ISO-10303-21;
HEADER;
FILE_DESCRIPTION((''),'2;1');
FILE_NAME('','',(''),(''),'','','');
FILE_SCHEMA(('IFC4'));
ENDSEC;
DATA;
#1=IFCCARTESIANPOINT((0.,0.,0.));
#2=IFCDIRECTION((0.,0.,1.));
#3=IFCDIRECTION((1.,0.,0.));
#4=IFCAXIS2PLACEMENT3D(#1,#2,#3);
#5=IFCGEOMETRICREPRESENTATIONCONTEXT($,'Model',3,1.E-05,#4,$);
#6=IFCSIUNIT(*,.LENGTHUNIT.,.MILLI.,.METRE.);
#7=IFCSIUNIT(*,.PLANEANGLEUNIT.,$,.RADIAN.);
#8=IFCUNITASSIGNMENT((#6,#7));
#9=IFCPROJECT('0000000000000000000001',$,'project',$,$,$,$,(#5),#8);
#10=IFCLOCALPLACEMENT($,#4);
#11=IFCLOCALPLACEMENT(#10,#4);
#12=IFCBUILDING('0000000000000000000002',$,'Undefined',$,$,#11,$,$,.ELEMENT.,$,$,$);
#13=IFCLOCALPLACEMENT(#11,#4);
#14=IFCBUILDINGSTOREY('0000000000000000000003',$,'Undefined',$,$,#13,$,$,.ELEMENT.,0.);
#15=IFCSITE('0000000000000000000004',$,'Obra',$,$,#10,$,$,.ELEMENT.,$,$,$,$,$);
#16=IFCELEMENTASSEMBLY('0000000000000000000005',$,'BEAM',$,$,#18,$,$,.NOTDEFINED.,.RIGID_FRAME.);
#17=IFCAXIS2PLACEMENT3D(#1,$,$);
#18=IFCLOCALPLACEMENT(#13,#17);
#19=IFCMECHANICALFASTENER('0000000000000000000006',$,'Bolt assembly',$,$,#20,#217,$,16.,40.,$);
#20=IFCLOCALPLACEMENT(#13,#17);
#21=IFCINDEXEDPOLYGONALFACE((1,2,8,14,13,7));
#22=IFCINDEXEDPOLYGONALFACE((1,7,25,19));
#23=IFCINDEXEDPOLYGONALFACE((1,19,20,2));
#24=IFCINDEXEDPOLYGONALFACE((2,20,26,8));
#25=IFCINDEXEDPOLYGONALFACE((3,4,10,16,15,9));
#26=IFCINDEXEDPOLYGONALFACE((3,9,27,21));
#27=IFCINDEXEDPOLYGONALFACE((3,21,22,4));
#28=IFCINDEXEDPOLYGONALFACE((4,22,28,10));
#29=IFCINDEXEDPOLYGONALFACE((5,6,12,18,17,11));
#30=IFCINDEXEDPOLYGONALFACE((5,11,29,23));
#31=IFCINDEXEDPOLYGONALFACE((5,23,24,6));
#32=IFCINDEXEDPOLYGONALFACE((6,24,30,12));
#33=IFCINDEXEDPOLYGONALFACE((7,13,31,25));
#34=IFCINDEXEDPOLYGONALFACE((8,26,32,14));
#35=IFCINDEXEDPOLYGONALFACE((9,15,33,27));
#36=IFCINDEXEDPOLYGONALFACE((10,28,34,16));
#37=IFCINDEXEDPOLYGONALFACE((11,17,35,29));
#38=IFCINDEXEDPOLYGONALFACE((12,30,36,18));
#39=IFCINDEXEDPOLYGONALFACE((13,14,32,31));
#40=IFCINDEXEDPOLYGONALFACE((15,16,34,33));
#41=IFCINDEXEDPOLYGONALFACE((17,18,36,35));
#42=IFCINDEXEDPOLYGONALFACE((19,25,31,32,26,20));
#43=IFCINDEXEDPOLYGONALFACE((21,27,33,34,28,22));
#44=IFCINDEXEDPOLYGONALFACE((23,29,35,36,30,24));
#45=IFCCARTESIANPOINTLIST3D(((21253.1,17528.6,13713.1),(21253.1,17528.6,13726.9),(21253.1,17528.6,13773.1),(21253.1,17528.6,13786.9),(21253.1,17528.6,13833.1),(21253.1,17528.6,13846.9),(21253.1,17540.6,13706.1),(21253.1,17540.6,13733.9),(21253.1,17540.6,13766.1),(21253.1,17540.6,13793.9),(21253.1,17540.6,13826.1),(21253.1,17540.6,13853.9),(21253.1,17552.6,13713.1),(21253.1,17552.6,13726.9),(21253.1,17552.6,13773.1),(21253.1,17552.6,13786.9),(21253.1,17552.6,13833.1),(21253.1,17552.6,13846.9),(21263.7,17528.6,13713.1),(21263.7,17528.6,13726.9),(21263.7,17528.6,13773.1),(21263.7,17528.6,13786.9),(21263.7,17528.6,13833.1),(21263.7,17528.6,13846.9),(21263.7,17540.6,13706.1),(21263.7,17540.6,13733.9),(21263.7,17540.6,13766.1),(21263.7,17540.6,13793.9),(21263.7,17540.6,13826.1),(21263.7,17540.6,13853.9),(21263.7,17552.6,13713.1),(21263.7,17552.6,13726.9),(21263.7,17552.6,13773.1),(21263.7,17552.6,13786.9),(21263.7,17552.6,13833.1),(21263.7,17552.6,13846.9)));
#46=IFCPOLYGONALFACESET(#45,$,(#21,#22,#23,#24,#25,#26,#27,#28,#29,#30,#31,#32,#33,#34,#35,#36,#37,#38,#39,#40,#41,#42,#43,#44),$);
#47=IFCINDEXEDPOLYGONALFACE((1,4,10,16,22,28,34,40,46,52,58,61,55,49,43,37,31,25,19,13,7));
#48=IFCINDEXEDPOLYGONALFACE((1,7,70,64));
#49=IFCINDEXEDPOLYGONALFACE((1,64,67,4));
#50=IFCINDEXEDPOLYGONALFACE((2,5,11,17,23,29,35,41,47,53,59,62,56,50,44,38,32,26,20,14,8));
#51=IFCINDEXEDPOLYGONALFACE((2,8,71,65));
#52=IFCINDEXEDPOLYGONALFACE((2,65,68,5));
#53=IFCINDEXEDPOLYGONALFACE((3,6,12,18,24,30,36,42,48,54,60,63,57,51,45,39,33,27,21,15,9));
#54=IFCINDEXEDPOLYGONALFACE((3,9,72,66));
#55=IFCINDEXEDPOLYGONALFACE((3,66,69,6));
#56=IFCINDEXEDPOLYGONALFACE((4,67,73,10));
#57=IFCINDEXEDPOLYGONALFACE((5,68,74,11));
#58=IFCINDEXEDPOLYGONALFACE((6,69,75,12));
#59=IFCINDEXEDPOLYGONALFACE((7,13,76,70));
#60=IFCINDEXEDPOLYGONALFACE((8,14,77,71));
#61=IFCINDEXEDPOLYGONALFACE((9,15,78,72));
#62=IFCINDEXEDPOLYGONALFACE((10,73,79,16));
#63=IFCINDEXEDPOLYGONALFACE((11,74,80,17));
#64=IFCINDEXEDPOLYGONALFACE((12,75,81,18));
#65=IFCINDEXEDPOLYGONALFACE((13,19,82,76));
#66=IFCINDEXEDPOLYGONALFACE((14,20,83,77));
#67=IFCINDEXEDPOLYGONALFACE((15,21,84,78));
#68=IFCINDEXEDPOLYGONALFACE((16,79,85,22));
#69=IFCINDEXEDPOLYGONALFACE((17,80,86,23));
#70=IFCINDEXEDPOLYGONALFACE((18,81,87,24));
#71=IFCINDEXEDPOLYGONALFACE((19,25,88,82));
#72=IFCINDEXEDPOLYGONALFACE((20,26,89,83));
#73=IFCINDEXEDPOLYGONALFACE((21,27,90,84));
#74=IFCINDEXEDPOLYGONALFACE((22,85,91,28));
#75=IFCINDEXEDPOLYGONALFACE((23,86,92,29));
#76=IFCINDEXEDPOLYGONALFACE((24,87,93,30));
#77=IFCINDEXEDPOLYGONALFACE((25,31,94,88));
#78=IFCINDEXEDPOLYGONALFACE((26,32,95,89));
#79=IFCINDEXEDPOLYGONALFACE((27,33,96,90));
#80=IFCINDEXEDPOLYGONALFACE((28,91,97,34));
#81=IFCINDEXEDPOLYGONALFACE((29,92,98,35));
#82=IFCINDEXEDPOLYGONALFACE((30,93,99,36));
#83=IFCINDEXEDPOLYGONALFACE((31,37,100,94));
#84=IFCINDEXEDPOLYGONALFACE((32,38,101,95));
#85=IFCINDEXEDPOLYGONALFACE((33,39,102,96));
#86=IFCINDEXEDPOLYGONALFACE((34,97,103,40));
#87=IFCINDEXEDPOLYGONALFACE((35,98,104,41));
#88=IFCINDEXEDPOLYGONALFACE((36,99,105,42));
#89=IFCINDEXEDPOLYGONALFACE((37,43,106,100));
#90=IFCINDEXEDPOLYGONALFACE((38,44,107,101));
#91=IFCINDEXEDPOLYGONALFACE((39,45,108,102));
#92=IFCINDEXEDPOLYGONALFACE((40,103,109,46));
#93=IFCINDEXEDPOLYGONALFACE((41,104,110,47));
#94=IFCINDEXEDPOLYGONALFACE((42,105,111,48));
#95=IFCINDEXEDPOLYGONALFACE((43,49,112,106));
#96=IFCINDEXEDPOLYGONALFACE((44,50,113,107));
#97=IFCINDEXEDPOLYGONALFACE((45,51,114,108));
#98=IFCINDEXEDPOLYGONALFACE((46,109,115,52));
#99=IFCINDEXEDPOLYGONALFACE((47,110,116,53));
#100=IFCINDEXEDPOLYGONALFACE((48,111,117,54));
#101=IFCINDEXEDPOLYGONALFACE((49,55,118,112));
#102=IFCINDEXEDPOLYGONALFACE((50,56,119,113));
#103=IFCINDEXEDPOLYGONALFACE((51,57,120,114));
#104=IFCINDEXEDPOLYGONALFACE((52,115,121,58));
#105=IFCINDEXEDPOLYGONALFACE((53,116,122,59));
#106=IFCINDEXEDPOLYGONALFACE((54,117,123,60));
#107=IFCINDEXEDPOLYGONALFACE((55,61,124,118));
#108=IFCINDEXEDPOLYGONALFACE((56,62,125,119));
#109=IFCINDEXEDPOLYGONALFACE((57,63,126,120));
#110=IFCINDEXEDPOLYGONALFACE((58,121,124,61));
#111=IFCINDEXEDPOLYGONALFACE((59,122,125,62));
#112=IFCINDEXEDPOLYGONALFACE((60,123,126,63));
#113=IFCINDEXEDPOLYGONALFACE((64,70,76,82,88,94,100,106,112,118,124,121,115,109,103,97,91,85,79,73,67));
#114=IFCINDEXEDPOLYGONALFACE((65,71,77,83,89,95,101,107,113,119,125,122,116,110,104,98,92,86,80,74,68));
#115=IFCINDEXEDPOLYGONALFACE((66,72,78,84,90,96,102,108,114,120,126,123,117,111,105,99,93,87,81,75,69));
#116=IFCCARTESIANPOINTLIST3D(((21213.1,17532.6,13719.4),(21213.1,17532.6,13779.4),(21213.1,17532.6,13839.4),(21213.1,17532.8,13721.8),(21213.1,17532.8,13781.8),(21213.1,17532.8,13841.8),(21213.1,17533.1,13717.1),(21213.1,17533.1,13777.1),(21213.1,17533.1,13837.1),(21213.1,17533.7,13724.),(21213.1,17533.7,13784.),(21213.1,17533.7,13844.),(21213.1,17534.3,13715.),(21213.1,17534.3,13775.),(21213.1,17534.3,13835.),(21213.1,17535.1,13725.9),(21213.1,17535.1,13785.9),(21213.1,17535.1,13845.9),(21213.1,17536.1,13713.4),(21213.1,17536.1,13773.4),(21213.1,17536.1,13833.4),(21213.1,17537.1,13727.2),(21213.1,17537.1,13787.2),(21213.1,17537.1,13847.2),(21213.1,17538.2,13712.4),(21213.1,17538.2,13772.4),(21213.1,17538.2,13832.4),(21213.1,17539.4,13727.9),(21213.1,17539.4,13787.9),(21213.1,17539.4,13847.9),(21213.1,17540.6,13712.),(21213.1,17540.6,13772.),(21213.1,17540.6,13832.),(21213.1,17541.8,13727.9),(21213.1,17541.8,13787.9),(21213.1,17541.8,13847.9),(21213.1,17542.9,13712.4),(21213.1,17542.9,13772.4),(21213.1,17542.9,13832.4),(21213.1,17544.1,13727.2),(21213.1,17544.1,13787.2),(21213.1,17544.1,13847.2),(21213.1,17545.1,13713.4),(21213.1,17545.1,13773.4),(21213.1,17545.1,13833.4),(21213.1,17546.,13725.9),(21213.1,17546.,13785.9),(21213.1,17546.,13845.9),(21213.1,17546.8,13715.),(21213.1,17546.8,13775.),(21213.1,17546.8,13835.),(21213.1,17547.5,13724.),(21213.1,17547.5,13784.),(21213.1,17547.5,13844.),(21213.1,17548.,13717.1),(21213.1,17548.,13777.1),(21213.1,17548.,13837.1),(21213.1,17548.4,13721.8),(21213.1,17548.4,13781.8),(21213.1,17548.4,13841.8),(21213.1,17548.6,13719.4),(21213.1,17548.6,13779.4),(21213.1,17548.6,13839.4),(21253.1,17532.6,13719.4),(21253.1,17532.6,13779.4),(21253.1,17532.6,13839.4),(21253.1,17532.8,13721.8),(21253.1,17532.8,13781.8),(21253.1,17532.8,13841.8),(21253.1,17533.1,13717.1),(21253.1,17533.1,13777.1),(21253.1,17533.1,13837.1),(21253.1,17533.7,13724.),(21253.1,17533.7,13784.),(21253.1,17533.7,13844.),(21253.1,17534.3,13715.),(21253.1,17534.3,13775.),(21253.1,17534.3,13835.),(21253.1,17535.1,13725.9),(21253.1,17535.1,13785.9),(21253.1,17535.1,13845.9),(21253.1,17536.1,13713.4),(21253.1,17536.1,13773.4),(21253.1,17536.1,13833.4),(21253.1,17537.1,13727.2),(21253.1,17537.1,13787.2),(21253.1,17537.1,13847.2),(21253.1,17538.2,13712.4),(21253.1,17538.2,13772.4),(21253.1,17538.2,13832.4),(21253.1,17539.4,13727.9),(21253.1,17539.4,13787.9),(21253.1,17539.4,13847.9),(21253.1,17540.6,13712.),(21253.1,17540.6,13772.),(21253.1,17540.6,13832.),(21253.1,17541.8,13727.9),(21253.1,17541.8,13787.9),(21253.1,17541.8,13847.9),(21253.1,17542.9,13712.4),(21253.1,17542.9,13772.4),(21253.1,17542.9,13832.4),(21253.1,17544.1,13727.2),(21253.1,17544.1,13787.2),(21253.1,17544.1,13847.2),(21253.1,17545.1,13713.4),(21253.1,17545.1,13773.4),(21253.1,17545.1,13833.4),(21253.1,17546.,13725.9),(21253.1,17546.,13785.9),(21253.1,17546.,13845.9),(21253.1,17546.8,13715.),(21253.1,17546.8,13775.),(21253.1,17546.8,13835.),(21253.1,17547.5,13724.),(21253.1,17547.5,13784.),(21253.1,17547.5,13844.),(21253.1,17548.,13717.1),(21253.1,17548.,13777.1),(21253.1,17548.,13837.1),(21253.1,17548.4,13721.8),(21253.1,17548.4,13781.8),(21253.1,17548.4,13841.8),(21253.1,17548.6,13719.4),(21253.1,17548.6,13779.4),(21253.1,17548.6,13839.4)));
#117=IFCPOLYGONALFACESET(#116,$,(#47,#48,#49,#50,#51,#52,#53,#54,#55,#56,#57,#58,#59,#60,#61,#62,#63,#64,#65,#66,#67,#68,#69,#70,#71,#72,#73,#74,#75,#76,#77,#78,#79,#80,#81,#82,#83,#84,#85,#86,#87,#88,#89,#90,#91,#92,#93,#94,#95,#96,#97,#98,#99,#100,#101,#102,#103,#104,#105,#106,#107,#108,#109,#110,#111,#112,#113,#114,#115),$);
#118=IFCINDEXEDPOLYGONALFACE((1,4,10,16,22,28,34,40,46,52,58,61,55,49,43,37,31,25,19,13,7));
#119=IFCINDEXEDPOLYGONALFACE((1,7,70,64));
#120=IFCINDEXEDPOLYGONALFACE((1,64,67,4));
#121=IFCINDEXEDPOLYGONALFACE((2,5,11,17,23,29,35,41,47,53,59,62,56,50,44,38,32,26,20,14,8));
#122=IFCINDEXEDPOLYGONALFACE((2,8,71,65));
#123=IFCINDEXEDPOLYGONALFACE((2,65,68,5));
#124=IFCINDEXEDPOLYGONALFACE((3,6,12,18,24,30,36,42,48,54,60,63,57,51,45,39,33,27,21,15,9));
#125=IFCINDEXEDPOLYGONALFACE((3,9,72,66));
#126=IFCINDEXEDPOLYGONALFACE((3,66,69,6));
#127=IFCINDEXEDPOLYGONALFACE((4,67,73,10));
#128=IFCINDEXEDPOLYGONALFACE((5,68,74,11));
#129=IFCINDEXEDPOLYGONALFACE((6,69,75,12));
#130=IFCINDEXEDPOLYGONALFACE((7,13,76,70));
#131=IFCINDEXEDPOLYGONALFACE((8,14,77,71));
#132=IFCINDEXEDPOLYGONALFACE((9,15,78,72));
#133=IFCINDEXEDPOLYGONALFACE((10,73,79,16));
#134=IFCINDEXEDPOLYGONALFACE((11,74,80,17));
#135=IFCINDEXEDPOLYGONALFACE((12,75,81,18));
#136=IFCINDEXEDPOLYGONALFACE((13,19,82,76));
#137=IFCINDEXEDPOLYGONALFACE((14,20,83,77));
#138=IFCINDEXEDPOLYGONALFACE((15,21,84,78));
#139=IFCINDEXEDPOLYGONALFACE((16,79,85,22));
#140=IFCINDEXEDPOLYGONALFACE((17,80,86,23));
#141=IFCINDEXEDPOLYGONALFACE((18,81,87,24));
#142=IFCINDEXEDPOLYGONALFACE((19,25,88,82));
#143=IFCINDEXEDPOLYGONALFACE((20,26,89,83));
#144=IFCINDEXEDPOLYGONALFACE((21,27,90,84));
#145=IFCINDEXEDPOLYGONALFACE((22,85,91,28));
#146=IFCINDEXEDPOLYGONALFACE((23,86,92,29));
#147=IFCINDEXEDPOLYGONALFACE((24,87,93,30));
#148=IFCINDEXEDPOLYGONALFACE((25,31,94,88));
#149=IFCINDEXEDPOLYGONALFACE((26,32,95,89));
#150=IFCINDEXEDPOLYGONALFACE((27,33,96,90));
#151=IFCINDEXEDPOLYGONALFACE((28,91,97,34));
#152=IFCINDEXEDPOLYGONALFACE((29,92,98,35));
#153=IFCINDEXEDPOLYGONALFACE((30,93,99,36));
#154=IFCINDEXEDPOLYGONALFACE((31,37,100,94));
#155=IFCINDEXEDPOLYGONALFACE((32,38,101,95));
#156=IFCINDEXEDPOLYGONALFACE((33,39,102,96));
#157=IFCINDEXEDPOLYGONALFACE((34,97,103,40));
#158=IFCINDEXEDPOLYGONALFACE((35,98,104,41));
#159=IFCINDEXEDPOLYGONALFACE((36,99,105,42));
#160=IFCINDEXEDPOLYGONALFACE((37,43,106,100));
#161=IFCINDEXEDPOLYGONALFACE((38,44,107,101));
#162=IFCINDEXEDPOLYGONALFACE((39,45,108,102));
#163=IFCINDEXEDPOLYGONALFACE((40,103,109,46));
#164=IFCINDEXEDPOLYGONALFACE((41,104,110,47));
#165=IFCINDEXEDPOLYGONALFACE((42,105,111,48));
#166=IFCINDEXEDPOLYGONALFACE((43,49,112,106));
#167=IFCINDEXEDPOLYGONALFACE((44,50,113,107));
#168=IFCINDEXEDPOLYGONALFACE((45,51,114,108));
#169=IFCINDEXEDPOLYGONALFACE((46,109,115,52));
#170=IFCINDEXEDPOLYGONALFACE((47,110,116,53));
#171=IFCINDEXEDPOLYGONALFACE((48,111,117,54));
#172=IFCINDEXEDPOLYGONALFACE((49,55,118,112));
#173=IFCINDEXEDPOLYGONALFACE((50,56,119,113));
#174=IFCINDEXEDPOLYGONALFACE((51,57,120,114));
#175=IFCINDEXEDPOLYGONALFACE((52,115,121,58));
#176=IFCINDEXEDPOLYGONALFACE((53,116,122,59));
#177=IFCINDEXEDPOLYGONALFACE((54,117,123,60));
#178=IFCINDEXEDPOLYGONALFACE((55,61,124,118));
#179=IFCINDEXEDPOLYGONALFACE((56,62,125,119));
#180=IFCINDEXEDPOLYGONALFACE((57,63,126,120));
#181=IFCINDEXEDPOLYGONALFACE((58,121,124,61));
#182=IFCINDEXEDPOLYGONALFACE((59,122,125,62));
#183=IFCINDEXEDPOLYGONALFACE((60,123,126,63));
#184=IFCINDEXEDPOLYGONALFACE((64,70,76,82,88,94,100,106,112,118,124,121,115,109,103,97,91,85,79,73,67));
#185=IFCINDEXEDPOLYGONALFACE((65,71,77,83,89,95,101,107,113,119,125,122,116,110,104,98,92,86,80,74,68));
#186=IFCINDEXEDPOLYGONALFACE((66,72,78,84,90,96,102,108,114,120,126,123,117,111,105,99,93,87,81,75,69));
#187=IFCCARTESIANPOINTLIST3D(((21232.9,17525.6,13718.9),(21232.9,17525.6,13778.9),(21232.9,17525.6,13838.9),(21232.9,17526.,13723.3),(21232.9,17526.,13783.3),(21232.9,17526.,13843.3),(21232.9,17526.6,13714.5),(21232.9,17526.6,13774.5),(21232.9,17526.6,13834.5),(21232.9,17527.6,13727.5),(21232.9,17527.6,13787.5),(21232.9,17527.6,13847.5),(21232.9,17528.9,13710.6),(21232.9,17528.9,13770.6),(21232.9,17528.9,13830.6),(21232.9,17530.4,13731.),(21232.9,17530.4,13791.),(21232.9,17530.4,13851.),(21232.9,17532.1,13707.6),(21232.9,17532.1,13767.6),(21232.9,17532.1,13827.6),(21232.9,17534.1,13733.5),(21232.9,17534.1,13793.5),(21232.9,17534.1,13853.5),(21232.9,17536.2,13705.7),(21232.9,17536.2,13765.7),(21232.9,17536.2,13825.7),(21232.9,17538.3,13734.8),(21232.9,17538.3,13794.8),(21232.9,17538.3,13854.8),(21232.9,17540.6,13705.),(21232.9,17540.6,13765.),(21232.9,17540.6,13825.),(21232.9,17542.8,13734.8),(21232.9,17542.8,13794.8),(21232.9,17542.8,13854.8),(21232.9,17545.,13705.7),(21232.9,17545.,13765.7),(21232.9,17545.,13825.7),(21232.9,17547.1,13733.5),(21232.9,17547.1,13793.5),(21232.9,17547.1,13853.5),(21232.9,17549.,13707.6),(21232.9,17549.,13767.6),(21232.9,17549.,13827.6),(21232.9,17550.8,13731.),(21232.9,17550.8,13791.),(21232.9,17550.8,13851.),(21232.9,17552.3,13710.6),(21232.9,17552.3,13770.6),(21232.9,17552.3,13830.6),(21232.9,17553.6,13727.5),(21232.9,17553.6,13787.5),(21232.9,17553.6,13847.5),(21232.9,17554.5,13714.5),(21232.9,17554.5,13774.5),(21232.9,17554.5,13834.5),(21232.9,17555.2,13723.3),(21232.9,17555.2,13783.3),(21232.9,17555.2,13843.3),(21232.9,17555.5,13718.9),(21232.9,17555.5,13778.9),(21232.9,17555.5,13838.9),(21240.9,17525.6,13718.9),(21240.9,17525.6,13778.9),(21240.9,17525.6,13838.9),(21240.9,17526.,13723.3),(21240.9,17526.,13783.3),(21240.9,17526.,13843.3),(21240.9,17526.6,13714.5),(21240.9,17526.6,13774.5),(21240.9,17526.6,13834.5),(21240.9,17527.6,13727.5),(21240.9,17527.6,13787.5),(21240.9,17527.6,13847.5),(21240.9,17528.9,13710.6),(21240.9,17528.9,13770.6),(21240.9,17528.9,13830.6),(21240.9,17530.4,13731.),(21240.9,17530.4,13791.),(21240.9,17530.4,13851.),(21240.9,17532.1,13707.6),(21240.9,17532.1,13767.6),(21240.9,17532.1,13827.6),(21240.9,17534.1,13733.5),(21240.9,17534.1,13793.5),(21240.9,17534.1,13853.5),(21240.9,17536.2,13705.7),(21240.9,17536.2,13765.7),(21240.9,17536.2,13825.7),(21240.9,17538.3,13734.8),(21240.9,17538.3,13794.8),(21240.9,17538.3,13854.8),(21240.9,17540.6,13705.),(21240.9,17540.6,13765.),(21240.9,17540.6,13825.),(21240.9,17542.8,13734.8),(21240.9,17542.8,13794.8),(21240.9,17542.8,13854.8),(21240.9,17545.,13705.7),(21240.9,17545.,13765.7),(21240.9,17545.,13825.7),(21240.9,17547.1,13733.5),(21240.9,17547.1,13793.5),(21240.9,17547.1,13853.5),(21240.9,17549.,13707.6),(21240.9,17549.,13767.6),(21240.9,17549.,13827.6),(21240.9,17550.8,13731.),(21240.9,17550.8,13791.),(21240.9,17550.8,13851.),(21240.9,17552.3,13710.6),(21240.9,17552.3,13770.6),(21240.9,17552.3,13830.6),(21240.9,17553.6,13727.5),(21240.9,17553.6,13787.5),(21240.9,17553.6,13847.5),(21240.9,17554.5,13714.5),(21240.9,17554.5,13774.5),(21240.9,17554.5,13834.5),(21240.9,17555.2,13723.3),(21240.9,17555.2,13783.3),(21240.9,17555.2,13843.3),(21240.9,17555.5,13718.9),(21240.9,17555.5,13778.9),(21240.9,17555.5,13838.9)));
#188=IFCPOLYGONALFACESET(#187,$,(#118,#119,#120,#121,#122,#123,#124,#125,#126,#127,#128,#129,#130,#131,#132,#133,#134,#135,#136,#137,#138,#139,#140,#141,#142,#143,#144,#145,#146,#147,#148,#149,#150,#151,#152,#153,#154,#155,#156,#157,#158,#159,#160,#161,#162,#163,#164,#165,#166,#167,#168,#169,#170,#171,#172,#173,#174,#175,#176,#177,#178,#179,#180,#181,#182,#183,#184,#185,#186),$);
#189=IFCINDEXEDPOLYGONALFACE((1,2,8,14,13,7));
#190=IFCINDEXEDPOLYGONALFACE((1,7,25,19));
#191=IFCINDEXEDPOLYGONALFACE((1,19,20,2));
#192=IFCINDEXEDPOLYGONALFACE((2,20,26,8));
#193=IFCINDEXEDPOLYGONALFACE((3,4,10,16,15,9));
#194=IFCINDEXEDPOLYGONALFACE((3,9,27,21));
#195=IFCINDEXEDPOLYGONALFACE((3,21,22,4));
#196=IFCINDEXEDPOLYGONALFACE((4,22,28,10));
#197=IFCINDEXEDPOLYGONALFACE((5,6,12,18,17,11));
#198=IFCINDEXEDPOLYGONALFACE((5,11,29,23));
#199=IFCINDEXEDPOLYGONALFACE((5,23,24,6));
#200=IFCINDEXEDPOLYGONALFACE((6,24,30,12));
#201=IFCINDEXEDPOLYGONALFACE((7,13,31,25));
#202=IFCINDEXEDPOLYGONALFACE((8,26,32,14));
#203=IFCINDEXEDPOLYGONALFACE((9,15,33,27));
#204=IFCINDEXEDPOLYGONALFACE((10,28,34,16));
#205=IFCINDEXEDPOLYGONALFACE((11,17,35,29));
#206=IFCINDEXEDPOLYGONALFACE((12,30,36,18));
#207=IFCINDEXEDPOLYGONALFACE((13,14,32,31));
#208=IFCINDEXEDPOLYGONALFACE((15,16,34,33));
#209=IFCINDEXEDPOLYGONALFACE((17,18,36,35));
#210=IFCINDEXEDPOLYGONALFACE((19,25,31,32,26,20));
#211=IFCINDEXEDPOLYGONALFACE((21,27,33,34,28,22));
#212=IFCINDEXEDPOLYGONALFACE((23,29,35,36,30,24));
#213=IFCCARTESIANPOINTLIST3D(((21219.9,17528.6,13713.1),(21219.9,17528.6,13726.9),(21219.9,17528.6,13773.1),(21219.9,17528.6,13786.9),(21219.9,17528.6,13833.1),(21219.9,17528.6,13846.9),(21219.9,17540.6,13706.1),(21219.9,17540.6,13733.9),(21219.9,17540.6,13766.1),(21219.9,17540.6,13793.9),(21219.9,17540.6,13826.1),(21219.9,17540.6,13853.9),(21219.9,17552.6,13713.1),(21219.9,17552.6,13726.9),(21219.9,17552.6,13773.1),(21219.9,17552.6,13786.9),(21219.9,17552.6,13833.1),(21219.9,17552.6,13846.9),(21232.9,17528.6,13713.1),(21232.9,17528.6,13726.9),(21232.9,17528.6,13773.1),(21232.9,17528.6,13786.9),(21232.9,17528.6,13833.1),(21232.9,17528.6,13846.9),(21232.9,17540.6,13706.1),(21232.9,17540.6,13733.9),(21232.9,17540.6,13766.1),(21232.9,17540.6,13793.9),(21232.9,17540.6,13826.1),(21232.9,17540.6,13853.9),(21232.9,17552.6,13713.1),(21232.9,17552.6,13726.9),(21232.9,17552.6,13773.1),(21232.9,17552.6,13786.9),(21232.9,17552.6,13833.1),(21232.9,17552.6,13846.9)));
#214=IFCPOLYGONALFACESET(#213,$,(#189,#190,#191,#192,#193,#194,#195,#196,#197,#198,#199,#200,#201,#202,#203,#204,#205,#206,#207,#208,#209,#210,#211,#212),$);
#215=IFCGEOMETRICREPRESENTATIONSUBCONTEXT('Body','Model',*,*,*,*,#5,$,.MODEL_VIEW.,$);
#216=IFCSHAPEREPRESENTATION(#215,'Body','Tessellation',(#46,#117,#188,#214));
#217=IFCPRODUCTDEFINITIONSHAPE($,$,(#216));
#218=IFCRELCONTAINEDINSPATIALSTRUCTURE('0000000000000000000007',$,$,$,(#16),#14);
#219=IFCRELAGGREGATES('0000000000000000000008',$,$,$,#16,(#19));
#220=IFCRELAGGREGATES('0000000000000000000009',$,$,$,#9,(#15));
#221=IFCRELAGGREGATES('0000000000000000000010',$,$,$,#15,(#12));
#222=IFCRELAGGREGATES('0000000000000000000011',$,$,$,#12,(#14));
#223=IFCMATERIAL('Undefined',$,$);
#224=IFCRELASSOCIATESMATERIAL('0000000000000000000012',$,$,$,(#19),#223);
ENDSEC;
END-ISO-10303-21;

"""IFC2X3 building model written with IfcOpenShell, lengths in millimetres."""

from ifc_helpers import new_model, si_unit, frame, origin_with_axes, origin_2d_with_axis, place, context, subcontext, project, spatial, polyline, circle, outline, extrude, source, transform, mapped, material, element, aggregate, save


model = new_model("IFC2X3")

# Units and contexts
model_context = context("Model", 3, precision=1e-05, world=origin_with_axes())
body_context = subcontext(model_context, "Body", "Model", "MODEL_VIEW")
ifc_project = project(units=[si_unit("LENGTHUNIT", "METRE", prefix="MILLI"), si_unit("PLANEANGLEUNIT", "RADIAN")], contexts=[model_context])

# Site, building, storey
site_placement = place(None, origin_with_axes())
site = spatial("IfcSite", under=ifc_project, at=site_placement, Name="Obra", CompositionType="ELEMENT")
building_placement = place(site_placement, origin_with_axes())
building = spatial("IfcBuilding", under=site, at=building_placement, Name="Undefined", CompositionType="ELEMENT")
storey_placement = place(building_placement, origin_with_axes())
storey = spatial("IfcBuildingStorey", under=building, at=storey_placement, Name="Undefined", CompositionType="ELEMENT", Elevation=0.0)

# Element assembly
assembly_1_placement = place(storey_placement, origin_with_axes())
assembly_1 = element("IfcElementAssembly", 1, at=assembly_1_placement, inside=storey, Name="BEAM", AssemblyPlace="NOTDEFINED", PredefinedType="RIGID_FRAME")

# Shared definitions
ifc_material_1 = material(Name="Undefined")
shared_shape_1 = source(origin_with_axes(), body_context, "Body", "SweptSolid", [
    extrude(outline(polyline([(13.9, 0.0), (6.9, 12.0), (-6.9, 12.0), (-13.9, 0.0), (-6.9, -12.0), (6.9, -12.0), (13.9, 0.0)])), frame((0.0, -13.6, 0.0), z_axis=(0.0, 1.0, 0.0), x_axis=(1.0, 0.0, 0.0)), (0.0, 0.0, 1.0), 10.6),
    extrude(circle(Radius=8.0, at=origin_2d_with_axis()), frame((0.0, -3.1, 0.0), z_axis=(0.0, 1.0, 0.0), x_axis=(1.0, 0.0, 0.0)), (0.0, 0.0, 1.0), 40.0),
    extrude(circle(Radius=15.0, at=origin_2d_with_axis()), frame((0.0, 9.1, 0.0), z_axis=(0.0, 1.0, 0.0), x_axis=(1.0, 0.0, 0.0)), (0.0, 0.0, 1.0), 8.0),
    extrude(outline(polyline([(13.9, 0.0), (6.9, 12.0), (-6.9, 12.0), (-13.9, 0.0), (-6.9, -12.0), (6.9, -12.0), (13.9, 0.0)])), frame((0.0, 17.1, 0.0), z_axis=(0.0, 1.0, 0.0), x_axis=(1.0, 0.0, 0.0)), (0.0, 0.0, 1.0), 13.0),
])

# Mechanical fastener
mechanical_fastener_1_placement = place(assembly_1_placement, frame((21250.0, 17490.6, 13879.0), z_axis=(0.000129, 1.0, 0.0), x_axis=(0.0, 0.0, -1.0)))
mechanical_fastener_1 = element("IfcMechanicalFastener", 2, at=mechanical_fastener_1_placement, material=ifc_material_1, Name="Bolt assembly", NominalDiameter=16.0, NominalLength=40.0, context=body_context, shape_type="MappedRepresentation", body=[
    mapped(shared_shape_1, transform((159.0, 0.0, 50.0))),
    mapped(shared_shape_1, transform((99.0, 0.0, 50.0))),
    mapped(shared_shape_1, transform((39.0, 0.0, 50.0))),
])
aggregate(assembly_1, [mechanical_fastener_1])

save(model, "model.ifc")
